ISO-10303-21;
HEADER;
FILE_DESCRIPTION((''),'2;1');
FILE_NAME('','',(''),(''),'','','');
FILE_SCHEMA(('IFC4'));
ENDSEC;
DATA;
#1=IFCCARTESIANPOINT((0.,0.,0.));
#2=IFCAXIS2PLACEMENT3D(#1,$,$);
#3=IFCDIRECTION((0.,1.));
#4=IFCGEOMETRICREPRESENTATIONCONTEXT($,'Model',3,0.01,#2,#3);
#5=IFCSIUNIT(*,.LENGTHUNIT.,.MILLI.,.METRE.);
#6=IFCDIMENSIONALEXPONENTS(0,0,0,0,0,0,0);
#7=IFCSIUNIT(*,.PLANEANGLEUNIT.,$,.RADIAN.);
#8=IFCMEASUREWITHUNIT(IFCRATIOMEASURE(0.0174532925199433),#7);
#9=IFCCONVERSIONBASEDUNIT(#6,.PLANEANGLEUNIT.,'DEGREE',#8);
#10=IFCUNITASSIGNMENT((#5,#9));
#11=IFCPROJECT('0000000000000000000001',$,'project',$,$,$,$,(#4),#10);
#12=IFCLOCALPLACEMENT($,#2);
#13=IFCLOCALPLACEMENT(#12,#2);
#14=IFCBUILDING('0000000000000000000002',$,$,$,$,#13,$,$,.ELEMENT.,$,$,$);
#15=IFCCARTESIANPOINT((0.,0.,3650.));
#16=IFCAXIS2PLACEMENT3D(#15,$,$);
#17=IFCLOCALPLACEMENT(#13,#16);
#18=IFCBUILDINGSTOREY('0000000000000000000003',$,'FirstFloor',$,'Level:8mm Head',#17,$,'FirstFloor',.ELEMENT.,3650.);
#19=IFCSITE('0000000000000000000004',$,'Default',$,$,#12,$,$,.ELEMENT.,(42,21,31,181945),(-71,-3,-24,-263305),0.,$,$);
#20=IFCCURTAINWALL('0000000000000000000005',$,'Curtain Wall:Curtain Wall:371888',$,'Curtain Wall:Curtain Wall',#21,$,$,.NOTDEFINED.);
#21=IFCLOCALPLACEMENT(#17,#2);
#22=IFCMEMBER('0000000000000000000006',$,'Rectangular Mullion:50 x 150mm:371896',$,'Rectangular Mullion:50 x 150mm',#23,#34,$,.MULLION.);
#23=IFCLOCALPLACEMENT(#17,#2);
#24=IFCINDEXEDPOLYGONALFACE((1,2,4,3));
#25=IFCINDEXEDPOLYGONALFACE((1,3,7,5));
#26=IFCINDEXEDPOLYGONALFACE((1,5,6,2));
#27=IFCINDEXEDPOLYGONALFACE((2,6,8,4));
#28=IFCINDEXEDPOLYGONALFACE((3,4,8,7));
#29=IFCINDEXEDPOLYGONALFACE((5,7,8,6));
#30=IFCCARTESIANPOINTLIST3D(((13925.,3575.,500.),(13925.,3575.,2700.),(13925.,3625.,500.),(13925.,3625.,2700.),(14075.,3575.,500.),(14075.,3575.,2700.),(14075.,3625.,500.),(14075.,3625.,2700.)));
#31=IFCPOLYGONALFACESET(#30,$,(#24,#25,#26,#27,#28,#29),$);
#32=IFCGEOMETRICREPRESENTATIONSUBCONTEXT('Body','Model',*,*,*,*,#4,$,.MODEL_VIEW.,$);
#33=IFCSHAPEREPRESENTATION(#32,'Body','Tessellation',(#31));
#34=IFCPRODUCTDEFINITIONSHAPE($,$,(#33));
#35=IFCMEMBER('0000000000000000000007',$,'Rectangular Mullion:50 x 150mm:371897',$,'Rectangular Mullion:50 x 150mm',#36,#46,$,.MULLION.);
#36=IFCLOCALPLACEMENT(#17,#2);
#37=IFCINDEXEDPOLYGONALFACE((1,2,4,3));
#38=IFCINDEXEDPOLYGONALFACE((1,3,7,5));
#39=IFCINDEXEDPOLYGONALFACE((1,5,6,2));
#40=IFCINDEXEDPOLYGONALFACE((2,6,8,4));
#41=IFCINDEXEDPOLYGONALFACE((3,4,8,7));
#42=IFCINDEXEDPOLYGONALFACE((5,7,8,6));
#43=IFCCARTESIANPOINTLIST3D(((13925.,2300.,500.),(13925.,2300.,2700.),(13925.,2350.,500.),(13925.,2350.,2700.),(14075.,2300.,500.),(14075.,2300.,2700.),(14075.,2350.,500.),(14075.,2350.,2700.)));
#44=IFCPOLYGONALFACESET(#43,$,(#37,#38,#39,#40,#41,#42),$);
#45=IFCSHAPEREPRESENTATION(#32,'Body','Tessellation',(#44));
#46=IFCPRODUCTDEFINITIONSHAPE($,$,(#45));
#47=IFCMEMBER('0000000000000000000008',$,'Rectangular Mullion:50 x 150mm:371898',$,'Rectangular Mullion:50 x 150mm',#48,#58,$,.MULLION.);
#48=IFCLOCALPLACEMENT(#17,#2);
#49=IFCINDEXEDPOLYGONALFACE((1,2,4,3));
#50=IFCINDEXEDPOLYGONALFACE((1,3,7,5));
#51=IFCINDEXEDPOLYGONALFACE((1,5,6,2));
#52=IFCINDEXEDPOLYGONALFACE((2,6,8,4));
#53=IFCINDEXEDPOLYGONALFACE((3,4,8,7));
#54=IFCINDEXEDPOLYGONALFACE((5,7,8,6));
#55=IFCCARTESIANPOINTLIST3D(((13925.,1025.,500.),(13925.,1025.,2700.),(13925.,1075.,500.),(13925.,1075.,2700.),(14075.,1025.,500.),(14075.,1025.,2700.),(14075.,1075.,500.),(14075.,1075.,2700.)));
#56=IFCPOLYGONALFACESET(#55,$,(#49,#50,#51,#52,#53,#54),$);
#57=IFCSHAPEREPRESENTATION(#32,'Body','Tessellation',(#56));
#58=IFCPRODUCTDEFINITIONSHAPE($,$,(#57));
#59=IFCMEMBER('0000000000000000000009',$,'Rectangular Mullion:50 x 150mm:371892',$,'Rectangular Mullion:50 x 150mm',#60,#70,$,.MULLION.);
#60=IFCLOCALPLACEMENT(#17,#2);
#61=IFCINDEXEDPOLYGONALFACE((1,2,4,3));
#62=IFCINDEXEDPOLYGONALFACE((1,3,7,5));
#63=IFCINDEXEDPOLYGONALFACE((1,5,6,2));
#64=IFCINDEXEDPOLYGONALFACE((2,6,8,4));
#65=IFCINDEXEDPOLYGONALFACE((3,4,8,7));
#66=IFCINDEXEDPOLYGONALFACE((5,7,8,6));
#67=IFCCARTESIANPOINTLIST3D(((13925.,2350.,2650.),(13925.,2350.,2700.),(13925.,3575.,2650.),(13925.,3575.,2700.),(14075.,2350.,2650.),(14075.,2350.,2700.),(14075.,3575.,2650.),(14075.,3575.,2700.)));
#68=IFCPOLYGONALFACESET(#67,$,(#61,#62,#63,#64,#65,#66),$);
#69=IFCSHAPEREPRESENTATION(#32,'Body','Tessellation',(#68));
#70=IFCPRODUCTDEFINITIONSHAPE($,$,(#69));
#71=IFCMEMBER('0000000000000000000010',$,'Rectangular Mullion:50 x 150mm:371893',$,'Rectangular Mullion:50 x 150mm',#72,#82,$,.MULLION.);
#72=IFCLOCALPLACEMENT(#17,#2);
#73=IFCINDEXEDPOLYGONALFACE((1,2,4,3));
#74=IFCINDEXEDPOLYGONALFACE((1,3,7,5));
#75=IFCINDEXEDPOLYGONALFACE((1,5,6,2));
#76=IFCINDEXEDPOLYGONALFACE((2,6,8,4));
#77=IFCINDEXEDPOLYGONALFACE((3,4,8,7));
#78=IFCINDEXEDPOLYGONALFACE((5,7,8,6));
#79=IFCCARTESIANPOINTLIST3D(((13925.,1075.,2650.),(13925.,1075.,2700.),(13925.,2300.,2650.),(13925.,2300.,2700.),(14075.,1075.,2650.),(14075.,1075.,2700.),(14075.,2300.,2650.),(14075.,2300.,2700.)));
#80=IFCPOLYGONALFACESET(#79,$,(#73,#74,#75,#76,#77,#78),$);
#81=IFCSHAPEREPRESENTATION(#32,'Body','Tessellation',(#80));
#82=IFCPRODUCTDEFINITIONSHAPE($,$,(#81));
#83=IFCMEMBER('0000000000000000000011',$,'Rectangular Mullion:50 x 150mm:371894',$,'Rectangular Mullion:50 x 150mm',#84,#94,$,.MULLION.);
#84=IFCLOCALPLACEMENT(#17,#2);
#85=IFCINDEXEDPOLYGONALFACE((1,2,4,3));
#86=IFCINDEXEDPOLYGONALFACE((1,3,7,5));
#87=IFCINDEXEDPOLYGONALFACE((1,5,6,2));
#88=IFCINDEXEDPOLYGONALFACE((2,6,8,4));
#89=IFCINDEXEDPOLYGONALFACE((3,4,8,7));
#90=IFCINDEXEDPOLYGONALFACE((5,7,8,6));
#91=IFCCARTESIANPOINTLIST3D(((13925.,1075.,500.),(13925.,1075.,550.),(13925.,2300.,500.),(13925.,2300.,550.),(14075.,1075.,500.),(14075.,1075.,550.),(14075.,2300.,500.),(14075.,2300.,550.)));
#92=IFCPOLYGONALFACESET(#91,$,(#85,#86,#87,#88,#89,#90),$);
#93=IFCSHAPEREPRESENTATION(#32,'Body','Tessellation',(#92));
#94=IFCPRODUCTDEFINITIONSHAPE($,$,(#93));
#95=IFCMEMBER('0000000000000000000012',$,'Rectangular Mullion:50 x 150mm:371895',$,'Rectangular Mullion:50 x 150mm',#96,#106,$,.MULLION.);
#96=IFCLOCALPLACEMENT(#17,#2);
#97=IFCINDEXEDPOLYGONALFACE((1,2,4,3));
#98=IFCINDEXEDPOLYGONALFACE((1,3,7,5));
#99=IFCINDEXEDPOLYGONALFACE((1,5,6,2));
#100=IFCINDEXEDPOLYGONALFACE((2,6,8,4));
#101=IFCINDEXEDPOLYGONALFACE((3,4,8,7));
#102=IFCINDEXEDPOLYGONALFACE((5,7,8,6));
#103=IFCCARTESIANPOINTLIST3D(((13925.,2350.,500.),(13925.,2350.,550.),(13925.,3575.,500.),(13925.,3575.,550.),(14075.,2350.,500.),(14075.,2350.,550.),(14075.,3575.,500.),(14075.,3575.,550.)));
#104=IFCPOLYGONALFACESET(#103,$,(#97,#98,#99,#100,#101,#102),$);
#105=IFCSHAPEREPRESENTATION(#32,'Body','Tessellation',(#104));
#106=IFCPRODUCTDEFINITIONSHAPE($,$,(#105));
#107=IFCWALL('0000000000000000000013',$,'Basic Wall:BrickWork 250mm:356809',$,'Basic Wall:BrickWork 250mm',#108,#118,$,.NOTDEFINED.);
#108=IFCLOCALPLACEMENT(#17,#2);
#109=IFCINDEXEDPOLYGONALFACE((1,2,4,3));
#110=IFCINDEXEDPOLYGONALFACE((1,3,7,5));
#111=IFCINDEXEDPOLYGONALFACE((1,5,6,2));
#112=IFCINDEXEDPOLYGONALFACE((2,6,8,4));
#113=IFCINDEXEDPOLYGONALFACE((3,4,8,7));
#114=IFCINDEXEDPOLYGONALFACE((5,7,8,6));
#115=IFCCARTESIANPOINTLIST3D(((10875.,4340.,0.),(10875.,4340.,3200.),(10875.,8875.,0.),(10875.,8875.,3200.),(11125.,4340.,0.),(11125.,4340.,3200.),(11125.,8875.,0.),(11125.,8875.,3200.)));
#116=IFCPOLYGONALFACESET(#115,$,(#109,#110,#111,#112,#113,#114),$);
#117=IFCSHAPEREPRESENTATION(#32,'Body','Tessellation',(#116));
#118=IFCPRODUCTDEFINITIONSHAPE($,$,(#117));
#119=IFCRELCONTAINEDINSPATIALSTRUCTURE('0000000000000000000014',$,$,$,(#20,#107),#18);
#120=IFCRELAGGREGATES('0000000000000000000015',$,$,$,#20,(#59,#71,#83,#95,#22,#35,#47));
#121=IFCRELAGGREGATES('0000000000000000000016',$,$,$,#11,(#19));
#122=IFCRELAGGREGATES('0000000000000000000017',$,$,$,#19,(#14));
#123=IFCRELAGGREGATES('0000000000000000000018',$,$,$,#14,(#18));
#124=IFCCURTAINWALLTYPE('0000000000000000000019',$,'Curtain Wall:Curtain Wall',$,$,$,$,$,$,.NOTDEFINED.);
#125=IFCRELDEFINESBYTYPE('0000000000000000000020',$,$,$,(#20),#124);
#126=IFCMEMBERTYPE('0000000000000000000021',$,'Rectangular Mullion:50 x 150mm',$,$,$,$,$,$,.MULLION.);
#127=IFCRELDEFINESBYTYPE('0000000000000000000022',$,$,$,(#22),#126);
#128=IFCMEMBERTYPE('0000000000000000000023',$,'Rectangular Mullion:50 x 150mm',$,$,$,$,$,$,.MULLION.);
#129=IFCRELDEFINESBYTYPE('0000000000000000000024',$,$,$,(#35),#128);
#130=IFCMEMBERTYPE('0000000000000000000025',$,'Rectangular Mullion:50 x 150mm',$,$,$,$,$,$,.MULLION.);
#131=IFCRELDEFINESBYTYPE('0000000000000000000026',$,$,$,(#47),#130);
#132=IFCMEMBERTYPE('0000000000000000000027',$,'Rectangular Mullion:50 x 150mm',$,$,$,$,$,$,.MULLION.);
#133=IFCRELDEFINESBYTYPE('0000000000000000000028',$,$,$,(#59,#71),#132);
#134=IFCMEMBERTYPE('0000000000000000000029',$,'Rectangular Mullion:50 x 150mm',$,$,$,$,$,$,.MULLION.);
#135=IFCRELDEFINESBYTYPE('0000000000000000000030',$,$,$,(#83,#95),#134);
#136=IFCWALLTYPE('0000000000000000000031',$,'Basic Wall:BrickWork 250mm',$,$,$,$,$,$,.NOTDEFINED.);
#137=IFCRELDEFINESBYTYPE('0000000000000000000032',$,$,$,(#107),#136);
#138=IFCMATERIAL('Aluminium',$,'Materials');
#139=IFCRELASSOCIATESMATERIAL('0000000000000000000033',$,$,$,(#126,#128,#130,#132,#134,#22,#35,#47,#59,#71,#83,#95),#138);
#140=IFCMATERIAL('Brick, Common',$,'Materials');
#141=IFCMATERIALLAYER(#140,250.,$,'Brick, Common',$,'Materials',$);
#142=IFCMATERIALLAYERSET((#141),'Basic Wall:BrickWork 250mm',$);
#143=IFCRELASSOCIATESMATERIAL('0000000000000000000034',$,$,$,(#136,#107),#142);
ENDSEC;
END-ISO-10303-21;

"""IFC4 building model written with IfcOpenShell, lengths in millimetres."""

from ifc_helpers import new_model, entity, si_unit, converted_unit, direction, frame, frame_2d, origin, origin_2d_with_axis, place, context, subcontext, project, spatial, rectangle, extrude, source, transform, mapped, material, layer, layer_set, layer_usage, material_profile, profile_set, profile_usage, type_object, type_shapes, element, aggregate, save


model = new_model("IFC4")

# Units and contexts
model_context = context("Model", 3, precision=0.01, world=origin(), true_north=direction((0.0, 1.0)))
body_context = subcontext(model_context, "Body", "Model", "MODEL_VIEW")
ifc_project = project(units=[si_unit("LENGTHUNIT", "METRE", prefix="MILLI"), converted_unit("PLANEANGLEUNIT", "DEGREE", entity("IfcRatioMeasure", 0.0174532925199433), si_unit("PLANEANGLEUNIT", "RADIAN"), dimensions=[0, 0, 0, 0, 0, 0, 0])], contexts=[model_context])

# Site, building, storey
site_placement = place(None, origin())
site = spatial("IfcSite", under=ifc_project, at=site_placement, Name="Default", CompositionType="ELEMENT", RefLatitude=(42, 21, 31, 181945), RefLongitude=(-71, -3, -24, -263305), RefElevation=0.0)
building_placement = place(site_placement, origin())
building = spatial("IfcBuilding", under=site, at=building_placement, CompositionType="ELEMENT")
storey_placement = place(building_placement, frame((0.0, 0.0, 3650.0)))
storey = spatial("IfcBuildingStorey", under=building, at=storey_placement, Name="FirstFloor", ObjectType="Level:8mm Head", LongName="FirstFloor", CompositionType="ELEMENT", Elevation=3650.0)

# Curtain wall, members
curtain_wall_type = type_object("IfcCurtainWallType", Name="Curtain Wall:Curtain Wall", PredefinedType="NOTDEFINED")
curtain_wall_placement = place(storey_placement, frame((0.0, 0.0, -3650.0)))
curtain_wall = element("IfcCurtainWall", 1, at=curtain_wall_placement, inside=storey, type_object=curtain_wall_type, Name="Curtain Wall:Curtain Wall:371888", ObjectType="Curtain Wall:Curtain Wall", PredefinedType="NOTDEFINED")
ifc_material_1 = material(Name="Aluminium", Category="Materials")
ifc_material_profile = material_profile(ifc_material_1, rectangle(XDim=150.0, YDim=50.0, at=origin_2d_with_axis()), Name="50 x 150mm")
ifc_profile_set = profile_set([ifc_material_profile], Name="50 x 150mm")
ifc_profile_usage_1 = profile_usage(ifc_profile_set)
member_type_1 = type_object("IfcMemberType", Name="Rectangular Mullion:50 x 150mm", PredefinedType="MULLION", material=ifc_profile_set)
shared_shape_1 = source(origin(), body_context, "Body", "SweptSolid", [
    extrude(rectangle(XDim=150.0, YDim=50.0, at=origin_2d_with_axis()), frame((-25.0, 0.0, -2200.0), z_axis=(0.0, 0.0, 1.0), x_axis=(0.0, -1.0, 0.0)), (0.0, 0.0, 1.0), 2200.0),
])
type_shapes(member_type_1, [shared_shape_1])
member_1_placement = place(storey_placement, frame((14000.0, 3625.0, 500.0), z_axis=(0.0, 0.0, -1.0), x_axis=(0.0, 1.0, 0.0)))
member_1 = element("IfcMember", 2, at=member_1_placement, type_object=member_type_1, material=ifc_profile_usage_1, Name="Rectangular Mullion:50 x 150mm:371896", ObjectType="Rectangular Mullion:50 x 150mm", PredefinedType="MULLION", context=body_context, shape_type="MappedRepresentation", body=[
    mapped(shared_shape_1, transform((0.0, 0.0, 0.0), scale=1.0)),
])
ifc_profile_usage_2 = profile_usage(ifc_profile_set)
member_type_2 = type_object("IfcMemberType", Name="Rectangular Mullion:50 x 150mm", PredefinedType="MULLION", material=ifc_profile_set)
shared_shape_2 = source(origin(), body_context, "Body", "SweptSolid", [
    extrude(rectangle(XDim=150.0, YDim=50.0, at=origin_2d_with_axis()), frame((0.0, 0.0, -2200.0), z_axis=(0.0, 0.0, 1.0), x_axis=(0.0, -1.0, 0.0)), (0.0, 0.0, 1.0), 2200.0),
])
type_shapes(member_type_2, [shared_shape_2])
member_2_placement = place(storey_placement, frame((14000.0, 2325.0, 500.0), z_axis=(0.0, 0.0, -1.0), x_axis=(0.0, 1.0, 0.0)))
member_2 = element("IfcMember", 3, at=member_2_placement, type_object=member_type_2, material=ifc_profile_usage_2, Name="Rectangular Mullion:50 x 150mm:371897", ObjectType="Rectangular Mullion:50 x 150mm", PredefinedType="MULLION", context=body_context, shape_type="MappedRepresentation", body=[
    mapped(shared_shape_2, transform((0.0, 0.0, 0.0), scale=1.0)),
])
ifc_profile_usage_3 = profile_usage(ifc_profile_set)
member_type_3 = type_object("IfcMemberType", Name="Rectangular Mullion:50 x 150mm", PredefinedType="MULLION", material=ifc_profile_set)
shared_shape_3 = source(origin(), body_context, "Body", "SweptSolid", [
    extrude(rectangle(XDim=150.0, YDim=50.0, at=origin_2d_with_axis()), frame((-25.0, 0.0, -2200.0), z_axis=(0.0, 0.0, 1.0), x_axis=(0.0, -1.0, 0.0)), (0.0, 0.0, 1.0), 2200.0),
])
type_shapes(member_type_3, [shared_shape_3])
member_3_placement = place(storey_placement, frame((14000.0, 1025.0, 2700.0), z_axis=(0.0, 0.0, 1.0), x_axis=(0.0, -1.0, 0.0)))
member_3 = element("IfcMember", 4, at=member_3_placement, type_object=member_type_3, material=ifc_profile_usage_3, Name="Rectangular Mullion:50 x 150mm:371898", ObjectType="Rectangular Mullion:50 x 150mm", PredefinedType="MULLION", context=body_context, shape_type="MappedRepresentation", body=[
    mapped(shared_shape_3, transform((0.0, 0.0, 0.0), scale=1.0)),
])
ifc_profile_usage_4 = profile_usage(ifc_profile_set)
member_type_4 = type_object("IfcMemberType", Name="Rectangular Mullion:50 x 150mm", PredefinedType="MULLION", material=ifc_profile_set)
shared_shape_4 = source(origin(), body_context, "Body", "SweptSolid", [
    extrude(rectangle(XDim=150.0, YDim=50.0, at=origin_2d_with_axis()), frame((-25.0, 0.0, -1225.0), z_axis=(0.0, 0.0, 1.0), x_axis=(0.0, -1.0, 0.0)), (0.0, 0.0, 1.0), 1225.0),
])
type_shapes(member_type_4, [shared_shape_4])
member_4_placement = place(storey_placement, frame((14000.0, 3575.0, 2700.0), z_axis=(0.0, 1.0, 0.0), x_axis=(0.0, 0.0, 1.0)))
member_4 = element("IfcMember", 5, at=member_4_placement, type_object=member_type_4, material=ifc_profile_usage_4, Name="Rectangular Mullion:50 x 150mm:371892", ObjectType="Rectangular Mullion:50 x 150mm", PredefinedType="MULLION", context=body_context, shape_type="MappedRepresentation", body=[
    mapped(shared_shape_4, transform((0.0, 0.0, 0.0), scale=1.0)),
])
ifc_profile_usage_5 = profile_usage(ifc_profile_set)
member_5_placement = place(storey_placement, frame((14000.0, 2300.0, 2700.0), z_axis=(0.0, 1.0, 0.0), x_axis=(0.0, 0.0, 1.0)))
member_5 = element("IfcMember", 6, at=member_5_placement, type_object=member_type_4, material=ifc_profile_usage_5, Name="Rectangular Mullion:50 x 150mm:371893", ObjectType="Rectangular Mullion:50 x 150mm", PredefinedType="MULLION", context=body_context, shape_type="MappedRepresentation", body=[
    mapped(shared_shape_4, transform((0.0, 0.0, 0.0), scale=1.0)),
])
ifc_profile_usage_6 = profile_usage(ifc_profile_set)
member_type_5 = type_object("IfcMemberType", Name="Rectangular Mullion:50 x 150mm", PredefinedType="MULLION", material=ifc_profile_set)
shared_shape_5 = source(origin(), body_context, "Body", "SweptSolid", [
    extrude(rectangle(XDim=150.0, YDim=50.0, at=origin_2d_with_axis()), frame((-25.0, 0.0, -1225.0), z_axis=(0.0, 0.0, 1.0), x_axis=(0.0, -1.0, 0.0)), (0.0, 0.0, 1.0), 1225.0),
])
type_shapes(member_type_5, [shared_shape_5])
member_6_placement = place(storey_placement, frame((14000.0, 1075.0, 500.0), z_axis=(0.0, -1.0, 0.0), x_axis=(0.0, 0.0, -1.0)))
member_6 = element("IfcMember", 7, at=member_6_placement, type_object=member_type_5, material=ifc_profile_usage_6, Name="Rectangular Mullion:50 x 150mm:371894", ObjectType="Rectangular Mullion:50 x 150mm", PredefinedType="MULLION", context=body_context, shape_type="MappedRepresentation", body=[
    mapped(shared_shape_5, transform((0.0, 0.0, 0.0), scale=1.0)),
])
ifc_profile_usage_7 = profile_usage(ifc_profile_set)
member_7_placement = place(storey_placement, frame((14000.0, 2350.0, 500.0), z_axis=(0.0, -1.0, 0.0), x_axis=(0.0, 0.0, -1.0)))
member_7 = element("IfcMember", 8, at=member_7_placement, type_object=member_type_5, material=ifc_profile_usage_7, Name="Rectangular Mullion:50 x 150mm:371895", ObjectType="Rectangular Mullion:50 x 150mm", PredefinedType="MULLION", context=body_context, shape_type="MappedRepresentation", body=[
    mapped(shared_shape_5, transform((0.0, 0.0, 0.0), scale=1.0)),
])
aggregate(curtain_wall, [member_4, member_5, member_6, member_7, member_1, member_2, member_3])

# Wall
ifc_material_2 = material(Name="Brick, Common", Category="Materials")
ifc_layer_1 = layer(ifc_material_2, 250.0, Name="Brick, Common", Category="Materials")
ifc_layer_set_1 = layer_set([ifc_layer_1], Name="Basic Wall:BrickWork 250mm")
ifc_layer_usage_1 = layer_usage(ifc_layer_set_1, "AXIS2", "POSITIVE", -125.0)
wall_type_1 = type_object("IfcWallType", Name="Basic Wall:BrickWork 250mm", PredefinedType="NOTDEFINED", material=ifc_layer_set_1)
wall_1_placement = place(storey_placement, frame((11000.0, 8875.0, 0.0), z_axis=(0.0, 0.0, 1.0), x_axis=(0.0, -1.0, 0.0)))
element("IfcWall", 9, at=wall_1_placement, inside=storey, type_object=wall_type_1, material=ifc_layer_usage_1, Name="Basic Wall:BrickWork 250mm:356809", ObjectType="Basic Wall:BrickWork 250mm", PredefinedType="NOTDEFINED", context=body_context, shape_type="SweptSolid", body=[
    extrude(rectangle(XDim=4535.0, YDim=250.0, at=frame_2d((2267.5, 0.0), x_axis=(-1.0, 0.0))), origin(), (0.0, 0.0, 1.0), 3200.0),
])

save(model, "model.ifc")
